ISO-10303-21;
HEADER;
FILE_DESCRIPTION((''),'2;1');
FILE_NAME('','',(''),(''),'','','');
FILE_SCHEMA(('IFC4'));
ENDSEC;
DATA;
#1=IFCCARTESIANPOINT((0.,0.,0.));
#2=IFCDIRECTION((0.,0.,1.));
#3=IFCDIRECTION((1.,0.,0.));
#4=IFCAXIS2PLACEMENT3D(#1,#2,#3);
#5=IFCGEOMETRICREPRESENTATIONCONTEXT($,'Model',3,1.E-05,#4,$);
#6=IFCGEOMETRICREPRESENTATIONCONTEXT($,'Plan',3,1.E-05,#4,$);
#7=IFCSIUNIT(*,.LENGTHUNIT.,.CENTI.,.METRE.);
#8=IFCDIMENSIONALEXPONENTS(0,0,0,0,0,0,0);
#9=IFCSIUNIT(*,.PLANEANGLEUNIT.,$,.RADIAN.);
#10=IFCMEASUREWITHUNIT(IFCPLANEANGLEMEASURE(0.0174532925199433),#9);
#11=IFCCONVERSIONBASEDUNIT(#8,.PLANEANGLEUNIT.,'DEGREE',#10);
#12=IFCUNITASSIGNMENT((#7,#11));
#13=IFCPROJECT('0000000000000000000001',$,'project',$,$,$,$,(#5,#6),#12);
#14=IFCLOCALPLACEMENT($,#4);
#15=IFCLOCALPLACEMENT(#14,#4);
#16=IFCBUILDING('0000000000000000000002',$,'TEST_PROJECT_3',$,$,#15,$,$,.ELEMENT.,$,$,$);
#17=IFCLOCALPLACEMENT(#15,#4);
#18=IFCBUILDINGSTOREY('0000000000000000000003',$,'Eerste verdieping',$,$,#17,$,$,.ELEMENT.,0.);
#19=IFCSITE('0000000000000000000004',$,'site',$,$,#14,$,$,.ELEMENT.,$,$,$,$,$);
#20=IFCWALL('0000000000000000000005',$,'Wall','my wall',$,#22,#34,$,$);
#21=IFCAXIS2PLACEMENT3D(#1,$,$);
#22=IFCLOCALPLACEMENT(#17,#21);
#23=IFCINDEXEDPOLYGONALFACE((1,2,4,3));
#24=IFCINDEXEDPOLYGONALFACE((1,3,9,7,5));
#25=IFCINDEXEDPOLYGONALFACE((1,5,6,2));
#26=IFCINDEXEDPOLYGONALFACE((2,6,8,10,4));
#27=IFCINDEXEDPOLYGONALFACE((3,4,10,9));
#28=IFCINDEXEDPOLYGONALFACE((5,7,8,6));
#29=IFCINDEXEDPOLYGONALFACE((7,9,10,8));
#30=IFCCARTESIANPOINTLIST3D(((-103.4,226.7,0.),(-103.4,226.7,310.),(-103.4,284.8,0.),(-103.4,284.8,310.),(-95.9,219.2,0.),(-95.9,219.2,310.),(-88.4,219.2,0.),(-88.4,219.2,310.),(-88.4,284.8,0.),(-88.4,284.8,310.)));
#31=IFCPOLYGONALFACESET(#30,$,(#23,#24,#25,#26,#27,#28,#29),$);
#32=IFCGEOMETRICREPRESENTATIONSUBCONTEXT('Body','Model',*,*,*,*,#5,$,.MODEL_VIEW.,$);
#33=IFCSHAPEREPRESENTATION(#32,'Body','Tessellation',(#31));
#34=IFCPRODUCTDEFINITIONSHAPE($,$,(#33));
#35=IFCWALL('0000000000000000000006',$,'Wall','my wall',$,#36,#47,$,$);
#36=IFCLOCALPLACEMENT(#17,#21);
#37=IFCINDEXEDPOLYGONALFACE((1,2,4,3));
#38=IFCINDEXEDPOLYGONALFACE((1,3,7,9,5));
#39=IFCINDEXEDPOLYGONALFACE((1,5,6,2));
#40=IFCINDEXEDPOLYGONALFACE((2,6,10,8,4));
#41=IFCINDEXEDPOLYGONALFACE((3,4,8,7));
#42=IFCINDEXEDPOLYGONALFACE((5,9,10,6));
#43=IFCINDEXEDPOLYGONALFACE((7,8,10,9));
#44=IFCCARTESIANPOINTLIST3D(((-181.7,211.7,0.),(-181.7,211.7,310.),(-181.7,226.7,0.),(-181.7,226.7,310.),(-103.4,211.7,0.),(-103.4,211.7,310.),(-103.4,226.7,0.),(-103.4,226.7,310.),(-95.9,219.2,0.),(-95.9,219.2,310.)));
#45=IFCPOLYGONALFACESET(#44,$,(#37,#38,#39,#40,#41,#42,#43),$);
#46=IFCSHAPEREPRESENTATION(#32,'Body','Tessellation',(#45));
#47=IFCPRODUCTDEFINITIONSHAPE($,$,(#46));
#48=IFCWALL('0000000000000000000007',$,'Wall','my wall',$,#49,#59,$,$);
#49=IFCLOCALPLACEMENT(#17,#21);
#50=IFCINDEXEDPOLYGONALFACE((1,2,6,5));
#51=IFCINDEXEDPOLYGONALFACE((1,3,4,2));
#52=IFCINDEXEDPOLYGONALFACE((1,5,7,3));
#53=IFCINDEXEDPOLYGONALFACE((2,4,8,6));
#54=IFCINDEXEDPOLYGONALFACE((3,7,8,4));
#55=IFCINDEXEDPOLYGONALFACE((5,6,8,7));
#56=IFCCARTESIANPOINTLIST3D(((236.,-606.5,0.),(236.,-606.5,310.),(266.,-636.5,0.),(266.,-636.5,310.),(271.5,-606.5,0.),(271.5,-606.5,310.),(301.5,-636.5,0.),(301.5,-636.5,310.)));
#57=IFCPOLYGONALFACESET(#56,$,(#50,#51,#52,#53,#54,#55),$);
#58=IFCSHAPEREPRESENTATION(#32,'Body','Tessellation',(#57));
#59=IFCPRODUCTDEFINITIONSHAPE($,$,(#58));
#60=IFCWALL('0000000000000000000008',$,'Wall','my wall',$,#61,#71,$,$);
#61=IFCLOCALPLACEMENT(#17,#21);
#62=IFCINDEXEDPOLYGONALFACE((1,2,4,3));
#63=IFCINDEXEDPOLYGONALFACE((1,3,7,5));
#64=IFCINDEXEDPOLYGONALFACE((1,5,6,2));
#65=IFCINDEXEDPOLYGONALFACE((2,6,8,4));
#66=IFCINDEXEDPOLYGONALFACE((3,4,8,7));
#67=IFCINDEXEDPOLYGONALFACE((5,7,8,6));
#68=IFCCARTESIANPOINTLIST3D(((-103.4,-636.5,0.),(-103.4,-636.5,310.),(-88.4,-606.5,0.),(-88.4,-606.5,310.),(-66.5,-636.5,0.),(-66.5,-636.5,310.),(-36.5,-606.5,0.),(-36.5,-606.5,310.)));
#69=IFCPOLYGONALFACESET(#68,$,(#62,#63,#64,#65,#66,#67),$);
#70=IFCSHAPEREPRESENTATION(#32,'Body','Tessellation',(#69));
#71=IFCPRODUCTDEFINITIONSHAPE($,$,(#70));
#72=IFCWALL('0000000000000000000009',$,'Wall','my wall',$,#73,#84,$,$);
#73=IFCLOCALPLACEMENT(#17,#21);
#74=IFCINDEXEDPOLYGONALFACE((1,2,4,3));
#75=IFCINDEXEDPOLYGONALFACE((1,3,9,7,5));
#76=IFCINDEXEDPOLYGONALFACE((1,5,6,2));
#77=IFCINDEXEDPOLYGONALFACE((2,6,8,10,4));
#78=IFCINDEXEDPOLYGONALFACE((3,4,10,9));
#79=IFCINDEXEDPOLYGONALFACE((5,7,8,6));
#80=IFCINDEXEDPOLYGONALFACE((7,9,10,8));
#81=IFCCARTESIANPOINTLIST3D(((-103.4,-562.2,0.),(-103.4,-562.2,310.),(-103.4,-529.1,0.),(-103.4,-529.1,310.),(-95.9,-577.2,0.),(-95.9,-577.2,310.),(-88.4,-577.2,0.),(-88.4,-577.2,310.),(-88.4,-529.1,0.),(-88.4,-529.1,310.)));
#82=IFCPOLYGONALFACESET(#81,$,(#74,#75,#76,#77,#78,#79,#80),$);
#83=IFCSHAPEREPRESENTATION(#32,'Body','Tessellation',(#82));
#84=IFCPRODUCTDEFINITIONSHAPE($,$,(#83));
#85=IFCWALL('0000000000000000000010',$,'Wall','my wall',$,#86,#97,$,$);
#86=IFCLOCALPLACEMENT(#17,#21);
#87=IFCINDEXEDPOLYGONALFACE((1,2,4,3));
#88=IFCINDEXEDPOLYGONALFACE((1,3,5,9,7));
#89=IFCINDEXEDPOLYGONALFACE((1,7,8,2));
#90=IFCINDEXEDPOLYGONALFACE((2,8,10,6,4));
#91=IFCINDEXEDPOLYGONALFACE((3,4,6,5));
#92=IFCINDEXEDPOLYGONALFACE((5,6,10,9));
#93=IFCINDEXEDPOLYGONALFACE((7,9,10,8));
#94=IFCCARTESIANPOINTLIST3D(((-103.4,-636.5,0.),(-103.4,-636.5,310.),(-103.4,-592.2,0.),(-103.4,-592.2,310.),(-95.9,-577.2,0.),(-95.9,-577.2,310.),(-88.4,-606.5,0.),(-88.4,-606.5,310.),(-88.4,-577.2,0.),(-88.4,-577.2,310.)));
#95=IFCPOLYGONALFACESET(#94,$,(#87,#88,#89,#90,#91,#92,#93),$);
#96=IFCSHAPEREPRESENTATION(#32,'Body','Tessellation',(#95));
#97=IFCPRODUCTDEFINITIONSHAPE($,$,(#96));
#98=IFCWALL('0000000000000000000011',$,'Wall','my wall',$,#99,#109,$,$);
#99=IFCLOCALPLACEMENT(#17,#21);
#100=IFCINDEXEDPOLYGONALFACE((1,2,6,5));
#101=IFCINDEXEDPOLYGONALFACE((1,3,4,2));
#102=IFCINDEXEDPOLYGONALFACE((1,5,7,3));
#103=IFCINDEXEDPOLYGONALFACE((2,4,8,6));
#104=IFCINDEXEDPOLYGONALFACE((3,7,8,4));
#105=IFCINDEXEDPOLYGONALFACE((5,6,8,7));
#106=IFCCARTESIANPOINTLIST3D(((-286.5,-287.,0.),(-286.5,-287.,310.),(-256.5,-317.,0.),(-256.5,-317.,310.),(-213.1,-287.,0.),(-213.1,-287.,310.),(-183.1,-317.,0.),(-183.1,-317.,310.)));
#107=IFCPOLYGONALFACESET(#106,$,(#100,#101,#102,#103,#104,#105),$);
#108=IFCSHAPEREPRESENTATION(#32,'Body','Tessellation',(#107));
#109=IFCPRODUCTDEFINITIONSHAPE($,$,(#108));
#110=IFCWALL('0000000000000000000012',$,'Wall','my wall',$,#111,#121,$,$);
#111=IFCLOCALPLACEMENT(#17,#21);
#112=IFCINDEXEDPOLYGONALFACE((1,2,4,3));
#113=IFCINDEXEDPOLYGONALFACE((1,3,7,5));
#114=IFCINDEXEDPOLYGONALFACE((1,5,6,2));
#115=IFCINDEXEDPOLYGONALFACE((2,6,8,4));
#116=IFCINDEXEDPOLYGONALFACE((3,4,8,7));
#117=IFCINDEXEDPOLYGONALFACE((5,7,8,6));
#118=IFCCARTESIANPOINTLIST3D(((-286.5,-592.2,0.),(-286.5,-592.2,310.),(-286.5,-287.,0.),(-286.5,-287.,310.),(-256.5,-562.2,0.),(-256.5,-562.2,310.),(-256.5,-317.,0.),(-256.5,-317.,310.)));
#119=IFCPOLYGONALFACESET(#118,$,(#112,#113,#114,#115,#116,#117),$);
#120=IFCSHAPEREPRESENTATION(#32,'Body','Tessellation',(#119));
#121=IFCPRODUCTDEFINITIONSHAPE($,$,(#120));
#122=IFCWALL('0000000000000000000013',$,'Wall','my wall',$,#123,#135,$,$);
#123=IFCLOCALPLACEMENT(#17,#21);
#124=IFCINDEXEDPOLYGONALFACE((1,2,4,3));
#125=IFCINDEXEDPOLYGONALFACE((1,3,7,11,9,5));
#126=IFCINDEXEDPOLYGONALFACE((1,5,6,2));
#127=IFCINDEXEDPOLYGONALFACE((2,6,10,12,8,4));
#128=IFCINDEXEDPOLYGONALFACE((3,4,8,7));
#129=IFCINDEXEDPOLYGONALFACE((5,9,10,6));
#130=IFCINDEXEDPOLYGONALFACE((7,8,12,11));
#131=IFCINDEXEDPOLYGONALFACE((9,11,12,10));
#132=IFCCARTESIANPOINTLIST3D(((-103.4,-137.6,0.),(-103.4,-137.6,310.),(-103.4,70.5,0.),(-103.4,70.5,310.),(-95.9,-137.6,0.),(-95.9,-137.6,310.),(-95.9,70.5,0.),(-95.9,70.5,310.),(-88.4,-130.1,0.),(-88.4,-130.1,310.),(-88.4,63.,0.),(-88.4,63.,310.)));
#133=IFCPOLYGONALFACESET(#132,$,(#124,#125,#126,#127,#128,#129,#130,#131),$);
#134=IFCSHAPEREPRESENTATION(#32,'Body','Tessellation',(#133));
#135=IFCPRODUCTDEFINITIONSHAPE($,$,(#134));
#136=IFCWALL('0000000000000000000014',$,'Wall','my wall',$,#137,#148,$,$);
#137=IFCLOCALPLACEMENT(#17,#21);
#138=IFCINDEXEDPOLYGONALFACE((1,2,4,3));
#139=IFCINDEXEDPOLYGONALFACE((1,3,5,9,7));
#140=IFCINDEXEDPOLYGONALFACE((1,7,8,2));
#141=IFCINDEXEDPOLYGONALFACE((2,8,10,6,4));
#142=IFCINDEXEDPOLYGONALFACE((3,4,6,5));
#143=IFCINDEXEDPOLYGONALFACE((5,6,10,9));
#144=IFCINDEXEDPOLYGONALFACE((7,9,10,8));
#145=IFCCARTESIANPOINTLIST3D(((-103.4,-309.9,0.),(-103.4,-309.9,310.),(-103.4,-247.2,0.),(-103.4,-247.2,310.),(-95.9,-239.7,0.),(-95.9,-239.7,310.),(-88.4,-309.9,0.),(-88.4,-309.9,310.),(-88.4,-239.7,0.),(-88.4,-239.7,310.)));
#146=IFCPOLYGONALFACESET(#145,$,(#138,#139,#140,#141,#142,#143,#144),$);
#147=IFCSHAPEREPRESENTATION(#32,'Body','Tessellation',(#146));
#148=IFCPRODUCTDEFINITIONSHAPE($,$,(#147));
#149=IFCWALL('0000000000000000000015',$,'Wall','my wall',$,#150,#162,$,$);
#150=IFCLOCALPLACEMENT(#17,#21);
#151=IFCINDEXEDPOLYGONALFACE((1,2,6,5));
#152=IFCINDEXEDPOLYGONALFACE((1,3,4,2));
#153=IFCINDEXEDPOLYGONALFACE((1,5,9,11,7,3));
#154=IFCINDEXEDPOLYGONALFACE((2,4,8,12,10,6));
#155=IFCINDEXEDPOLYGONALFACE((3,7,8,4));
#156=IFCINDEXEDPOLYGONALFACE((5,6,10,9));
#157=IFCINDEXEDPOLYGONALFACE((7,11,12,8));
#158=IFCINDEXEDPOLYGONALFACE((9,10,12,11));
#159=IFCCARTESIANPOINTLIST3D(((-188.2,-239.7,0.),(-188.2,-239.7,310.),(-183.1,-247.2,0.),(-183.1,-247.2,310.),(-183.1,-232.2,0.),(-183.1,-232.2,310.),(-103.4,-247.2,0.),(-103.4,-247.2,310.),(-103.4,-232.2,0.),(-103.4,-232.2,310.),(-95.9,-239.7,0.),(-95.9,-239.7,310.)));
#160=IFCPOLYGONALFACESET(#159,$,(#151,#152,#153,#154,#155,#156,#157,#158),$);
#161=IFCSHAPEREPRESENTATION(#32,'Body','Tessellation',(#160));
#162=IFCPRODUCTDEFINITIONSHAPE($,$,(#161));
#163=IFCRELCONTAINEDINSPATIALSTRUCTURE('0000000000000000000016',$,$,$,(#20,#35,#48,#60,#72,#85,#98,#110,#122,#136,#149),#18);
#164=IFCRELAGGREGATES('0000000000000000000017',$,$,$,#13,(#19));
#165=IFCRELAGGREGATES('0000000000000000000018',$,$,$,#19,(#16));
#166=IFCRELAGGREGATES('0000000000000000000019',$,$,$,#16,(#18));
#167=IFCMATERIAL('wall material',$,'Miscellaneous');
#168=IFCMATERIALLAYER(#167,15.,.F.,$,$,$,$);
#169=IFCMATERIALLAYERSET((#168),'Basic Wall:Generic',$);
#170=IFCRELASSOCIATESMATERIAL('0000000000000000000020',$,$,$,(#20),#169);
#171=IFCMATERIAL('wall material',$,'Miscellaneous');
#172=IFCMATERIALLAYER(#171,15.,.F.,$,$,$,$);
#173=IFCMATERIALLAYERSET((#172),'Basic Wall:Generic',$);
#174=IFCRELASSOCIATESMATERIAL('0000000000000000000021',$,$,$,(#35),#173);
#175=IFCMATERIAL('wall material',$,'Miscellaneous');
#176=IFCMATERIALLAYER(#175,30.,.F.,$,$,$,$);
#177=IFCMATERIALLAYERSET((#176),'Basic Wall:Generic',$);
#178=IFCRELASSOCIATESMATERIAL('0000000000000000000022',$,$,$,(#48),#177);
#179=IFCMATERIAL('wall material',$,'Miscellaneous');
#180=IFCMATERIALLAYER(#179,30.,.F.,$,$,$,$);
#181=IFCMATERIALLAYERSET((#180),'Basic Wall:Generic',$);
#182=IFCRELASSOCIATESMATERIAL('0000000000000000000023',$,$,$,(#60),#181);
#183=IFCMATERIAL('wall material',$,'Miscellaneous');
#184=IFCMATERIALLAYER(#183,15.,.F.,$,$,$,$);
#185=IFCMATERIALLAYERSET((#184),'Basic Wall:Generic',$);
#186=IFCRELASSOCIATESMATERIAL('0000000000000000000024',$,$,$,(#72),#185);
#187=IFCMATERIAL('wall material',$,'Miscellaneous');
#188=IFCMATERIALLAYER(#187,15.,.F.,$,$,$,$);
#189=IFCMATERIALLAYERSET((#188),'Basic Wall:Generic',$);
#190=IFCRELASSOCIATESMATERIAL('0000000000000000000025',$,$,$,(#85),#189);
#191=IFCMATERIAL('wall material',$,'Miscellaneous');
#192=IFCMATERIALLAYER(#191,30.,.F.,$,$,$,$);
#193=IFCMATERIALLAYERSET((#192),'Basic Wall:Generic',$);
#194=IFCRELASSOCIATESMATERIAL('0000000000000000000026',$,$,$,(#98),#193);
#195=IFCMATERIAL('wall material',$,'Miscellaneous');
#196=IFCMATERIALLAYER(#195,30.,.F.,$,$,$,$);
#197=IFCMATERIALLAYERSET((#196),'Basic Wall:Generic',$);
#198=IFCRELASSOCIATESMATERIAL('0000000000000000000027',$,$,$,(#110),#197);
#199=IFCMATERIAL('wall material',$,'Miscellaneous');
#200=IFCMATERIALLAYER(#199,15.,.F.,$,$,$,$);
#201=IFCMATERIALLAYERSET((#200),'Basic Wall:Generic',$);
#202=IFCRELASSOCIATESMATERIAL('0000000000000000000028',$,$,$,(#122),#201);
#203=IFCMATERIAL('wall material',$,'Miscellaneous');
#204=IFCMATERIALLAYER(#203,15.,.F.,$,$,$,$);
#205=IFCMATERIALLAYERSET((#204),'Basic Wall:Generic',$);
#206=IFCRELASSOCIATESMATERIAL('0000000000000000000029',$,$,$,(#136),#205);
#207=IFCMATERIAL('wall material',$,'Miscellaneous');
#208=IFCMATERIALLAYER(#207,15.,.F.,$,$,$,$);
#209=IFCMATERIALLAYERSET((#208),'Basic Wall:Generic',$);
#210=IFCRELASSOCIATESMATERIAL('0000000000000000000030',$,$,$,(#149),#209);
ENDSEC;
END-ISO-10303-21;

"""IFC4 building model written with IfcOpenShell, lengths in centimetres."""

from ifc_helpers import new_model, entity, si_unit, converted_unit, origin_with_axes, place, context, subcontext, project, spatial, polyline, outline, extrude, material, layer, layer_set, layer_usage, element, save


model = new_model("IFC4")

# Units and contexts
model_context = context("Model", 3, precision=1e-05, world=origin_with_axes())
plan_context = context("Plan", 3, precision=1e-05, world=origin_with_axes())
body_context = subcontext(model_context, "Body", "Model", "MODEL_VIEW")
ifc_project = project(units=[si_unit("LENGTHUNIT", "METRE", prefix="CENTI"), converted_unit("PLANEANGLEUNIT", "DEGREE", entity("IfcPlaneAngleMeasure", 0.0174532925199433), si_unit("PLANEANGLEUNIT", "RADIAN"), dimensions=[0, 0, 0, 0, 0, 0, 0])], contexts=[model_context, plan_context])

# Site, building, storey
site_placement = place(None, origin_with_axes())
site = spatial("IfcSite", under=ifc_project, at=site_placement, Name="site", CompositionType="ELEMENT")
building_placement = place(site_placement, origin_with_axes())
building = spatial("IfcBuilding", under=site, at=building_placement, Name="TEST_PROJECT_3", CompositionType="ELEMENT")
storey_placement = place(building_placement, origin_with_axes())
storey = spatial("IfcBuildingStorey", under=building, at=storey_placement, Name="Eerste verdieping", CompositionType="ELEMENT", Elevation=0.0)

# Wall
ifc_material_1 = material(Name="wall material", Category="Miscellaneous")
ifc_layer_1 = layer(ifc_material_1, 15.0, ventilated=False)
ifc_layer_set_1 = layer_set([ifc_layer_1], Name="Basic Wall:Generic")
ifc_layer_usage_1 = layer_usage(ifc_layer_set_1, "AXIS3", "NEGATIVE", 0.0)
wall_1_placement = place(storey_placement, origin_with_axes())
element("IfcWall", 1, at=wall_1_placement, inside=storey, material=ifc_layer_usage_1, Name="Wall", Description="my wall", context=body_context, shape_type="SweptSolid", body=[
    extrude(outline(polyline([(-103.4, 226.7, 0.0), (-103.4, 284.8, 0.0), (-88.4, 284.8, 0.0), (-88.4, 219.2, 0.0), (-95.9, 219.2, 0.0), (-103.4, 226.7, 0.0)])), origin_with_axes(), (0.0, 0.0, 1.0), 310.0),
])

# Walls
ifc_material_2 = material(Name="wall material", Category="Miscellaneous")
ifc_layer_2 = layer(ifc_material_2, 15.0, ventilated=False)
ifc_layer_set_2 = layer_set([ifc_layer_2], Name="Basic Wall:Generic")
ifc_layer_usage_2 = layer_usage(ifc_layer_set_2, "AXIS3", "NEGATIVE", 0.0)
wall_2_placement = place(storey_placement, origin_with_axes())
element("IfcWall", 2, at=wall_2_placement, inside=storey, material=ifc_layer_usage_2, Name="Wall", Description="my wall", context=body_context, shape_type="SweptSolid", body=[
    extrude(outline(polyline([(-181.7, 211.7, 0.0), (-181.7, 226.7, 0.0), (-103.4, 226.7, 0.0), (-95.9, 219.2, 0.0), (-103.4, 211.7, 0.0), (-181.7, 211.7, 0.0)])), origin_with_axes(), (0.0, 0.0, 1.0), 310.0),
])
ifc_material_3 = material(Name="wall material", Category="Miscellaneous")
ifc_layer_3 = layer(ifc_material_3, 30.0, ventilated=False)
ifc_layer_set_3 = layer_set([ifc_layer_3], Name="Basic Wall:Generic")
ifc_layer_usage_3 = layer_usage(ifc_layer_set_3, "AXIS3", "NEGATIVE", 0.0)
wall_3_placement = place(storey_placement, origin_with_axes())
element("IfcWall", 3, at=wall_3_placement, inside=storey, material=ifc_layer_usage_3, Name="Wall", Description="my wall", context=body_context, shape_type="SweptSolid", body=[
    extrude(outline(polyline([(266.0, -636.5, 0.0), (236.0, -606.5, 0.0), (271.5, -606.5, 0.0), (301.5, -636.5, 0.0), (266.0, -636.5, 0.0)])), origin_with_axes(), (0.0, 0.0, 1.0), 310.0),
])

# Walls
ifc_material_4 = material(Name="wall material", Category="Miscellaneous")
ifc_layer_4 = layer(ifc_material_4, 30.0, ventilated=False)
ifc_layer_set_4 = layer_set([ifc_layer_4], Name="Basic Wall:Generic")
ifc_layer_usage_4 = layer_usage(ifc_layer_set_4, "AXIS3", "NEGATIVE", 0.0)
wall_4_placement = place(storey_placement, origin_with_axes())
element("IfcWall", 4, at=wall_4_placement, inside=storey, material=ifc_layer_usage_4, Name="Wall", Description="my wall", context=body_context, shape_type="SweptSolid", body=[
    extrude(outline(polyline([(-103.4, -636.5, 0.0), (-88.4, -606.5, 0.0), (-36.5, -606.5, 0.0), (-66.5, -636.5, 0.0), (-103.4, -636.5, 0.0)])), origin_with_axes(), (0.0, 0.0, 1.0), 310.0),
])
ifc_material_5 = material(Name="wall material", Category="Miscellaneous")
ifc_layer_5 = layer(ifc_material_5, 15.0, ventilated=False)
ifc_layer_set_5 = layer_set([ifc_layer_5], Name="Basic Wall:Generic")
ifc_layer_usage_5 = layer_usage(ifc_layer_set_5, "AXIS3", "NEGATIVE", 0.0)
wall_5_placement = place(storey_placement, origin_with_axes())
element("IfcWall", 5, at=wall_5_placement, inside=storey, material=ifc_layer_usage_5, Name="Wall", Description="my wall", context=body_context, shape_type="SweptSolid", body=[
    extrude(outline(polyline([(-103.4, -562.2, 0.0), (-103.4, -529.1, 0.0), (-88.4, -529.1, 0.0), (-88.4, -577.2, 0.0), (-95.9, -577.2, 0.0), (-103.4, -562.2, 0.0)])), origin_with_axes(), (0.0, 0.0, 1.0), 310.0),
])
ifc_material_6 = material(Name="wall material", Category="Miscellaneous")
ifc_layer_6 = layer(ifc_material_6, 15.0, ventilated=False)
ifc_layer_set_6 = layer_set([ifc_layer_6], Name="Basic Wall:Generic")
ifc_layer_usage_6 = layer_usage(ifc_layer_set_6, "AXIS3", "NEGATIVE", 0.0)
wall_6_placement = place(storey_placement, origin_with_axes())
element("IfcWall", 6, at=wall_6_placement, inside=storey, material=ifc_layer_usage_6, Name="Wall", Description="my wall", context=body_context, shape_type="SweptSolid", body=[
    extrude(outline(polyline([(-103.4, -636.5, 0.0), (-103.4, -592.2, 0.0), (-95.9, -577.2, 0.0), (-88.4, -577.2, 0.0), (-88.4, -606.5, 0.0), (-103.4, -636.5, 0.0)])), origin_with_axes(), (0.0, 0.0, 1.0), 310.0),
])

# Walls
ifc_material_7 = material(Name="wall material", Category="Miscellaneous")
ifc_layer_7 = layer(ifc_material_7, 30.0, ventilated=False)
ifc_layer_set_7 = layer_set([ifc_layer_7], Name="Basic Wall:Generic")
ifc_layer_usage_7 = layer_usage(ifc_layer_set_7, "AXIS3", "NEGATIVE", 0.0)
wall_7_placement = place(storey_placement, origin_with_axes())
element("IfcWall", 7, at=wall_7_placement, inside=storey, material=ifc_layer_usage_7, Name="Wall", Description="my wall", context=body_context, shape_type="SweptSolid", body=[
    extrude(outline(polyline([(-256.5, -317.0, 0.0), (-286.5, -287.0, 0.0), (-213.1, -287.0, 0.0), (-183.1, -317.0, 0.0), (-256.5, -317.0, 0.0)])), origin_with_axes(), (0.0, 0.0, 1.0), 310.0),
])
ifc_material_8 = material(Name="wall material", Category="Miscellaneous")
ifc_layer_8 = layer(ifc_material_8, 30.0, ventilated=False)
ifc_layer_set_8 = layer_set([ifc_layer_8], Name="Basic Wall:Generic")
ifc_layer_usage_8 = layer_usage(ifc_layer_set_8, "AXIS3", "NEGATIVE", 0.0)
wall_8_placement = place(storey_placement, origin_with_axes())
element("IfcWall", 8, at=wall_8_placement, inside=storey, material=ifc_layer_usage_8, Name="Wall", Description="my wall", context=body_context, shape_type="SweptSolid", body=[
    extrude(outline(polyline([(-286.5, -592.2, 0.0), (-286.5, -287.0, 0.0), (-256.5, -317.0, 0.0), (-256.5, -562.2, 0.0), (-286.5, -592.2, 0.0)])), origin_with_axes(), (0.0, 0.0, 1.0), 310.0),
])
ifc_material_9 = material(Name="wall material", Category="Miscellaneous")
ifc_layer_9 = layer(ifc_material_9, 15.0, ventilated=False)
ifc_layer_set_9 = layer_set([ifc_layer_9], Name="Basic Wall:Generic")
ifc_layer_usage_9 = layer_usage(ifc_layer_set_9, "AXIS3", "NEGATIVE", 0.0)
wall_9_placement = place(storey_placement, origin_with_axes())
element("IfcWall", 9, at=wall_9_placement, inside=storey, material=ifc_layer_usage_9, Name="Wall", Description="my wall", context=body_context, shape_type="SweptSolid", body=[
    extrude(outline(polyline([(-95.9, -137.6, 0.0), (-103.4, -137.6, 0.0), (-103.4, 70.5, 0.0), (-95.9, 70.5, 0.0), (-88.4, 63.0, 0.0), (-88.4, -130.1, 0.0), (-95.9, -137.6, 0.0)])), origin_with_axes(), (0.0, 0.0, 1.0), 310.0),
])

# Walls
ifc_material_10 = material(Name="wall material", Category="Miscellaneous")
ifc_layer_10 = layer(ifc_material_10, 15.0, ventilated=False)
ifc_layer_set_10 = layer_set([ifc_layer_10], Name="Basic Wall:Generic")
ifc_layer_usage_10 = layer_usage(ifc_layer_set_10, "AXIS3", "NEGATIVE", 0.0)
wall_10_placement = place(storey_placement, origin_with_axes())
element("IfcWall", 10, at=wall_10_placement, inside=storey, material=ifc_layer_usage_10, Name="Wall", Description="my wall", context=body_context, shape_type="SweptSolid", body=[
    extrude(outline(polyline([(-103.4, -309.9, 0.0), (-103.4, -247.2, 0.0), (-95.9, -239.7, 0.0), (-88.4, -239.7, 0.0), (-88.4, -309.9, 0.0), (-103.4, -309.9, 0.0)])), origin_with_axes(), (0.0, 0.0, 1.0), 310.0),
])
ifc_material_11 = material(Name="wall material", Category="Miscellaneous")
ifc_layer_11 = layer(ifc_material_11, 15.0, ventilated=False)
ifc_layer_set_11 = layer_set([ifc_layer_11], Name="Basic Wall:Generic")
ifc_layer_usage_11 = layer_usage(ifc_layer_set_11, "AXIS3", "NEGATIVE", 0.0)
wall_11_placement = place(storey_placement, origin_with_axes())
element("IfcWall", 11, at=wall_11_placement, inside=storey, material=ifc_layer_usage_11, Name="Wall", Description="my wall", context=body_context, shape_type="SweptSolid", body=[
    extrude(outline(polyline([(-183.1, -247.2, 0.0), (-188.2, -239.7, 0.0), (-183.1, -232.2, 0.0), (-103.4, -232.2, 0.0), (-95.9, -239.7, 0.0), (-103.4, -247.2, 0.0), (-183.1, -247.2, 0.0)])), origin_with_axes(), (0.0, 0.0, 1.0), 310.0),
])

save(model, "model.ifc")
